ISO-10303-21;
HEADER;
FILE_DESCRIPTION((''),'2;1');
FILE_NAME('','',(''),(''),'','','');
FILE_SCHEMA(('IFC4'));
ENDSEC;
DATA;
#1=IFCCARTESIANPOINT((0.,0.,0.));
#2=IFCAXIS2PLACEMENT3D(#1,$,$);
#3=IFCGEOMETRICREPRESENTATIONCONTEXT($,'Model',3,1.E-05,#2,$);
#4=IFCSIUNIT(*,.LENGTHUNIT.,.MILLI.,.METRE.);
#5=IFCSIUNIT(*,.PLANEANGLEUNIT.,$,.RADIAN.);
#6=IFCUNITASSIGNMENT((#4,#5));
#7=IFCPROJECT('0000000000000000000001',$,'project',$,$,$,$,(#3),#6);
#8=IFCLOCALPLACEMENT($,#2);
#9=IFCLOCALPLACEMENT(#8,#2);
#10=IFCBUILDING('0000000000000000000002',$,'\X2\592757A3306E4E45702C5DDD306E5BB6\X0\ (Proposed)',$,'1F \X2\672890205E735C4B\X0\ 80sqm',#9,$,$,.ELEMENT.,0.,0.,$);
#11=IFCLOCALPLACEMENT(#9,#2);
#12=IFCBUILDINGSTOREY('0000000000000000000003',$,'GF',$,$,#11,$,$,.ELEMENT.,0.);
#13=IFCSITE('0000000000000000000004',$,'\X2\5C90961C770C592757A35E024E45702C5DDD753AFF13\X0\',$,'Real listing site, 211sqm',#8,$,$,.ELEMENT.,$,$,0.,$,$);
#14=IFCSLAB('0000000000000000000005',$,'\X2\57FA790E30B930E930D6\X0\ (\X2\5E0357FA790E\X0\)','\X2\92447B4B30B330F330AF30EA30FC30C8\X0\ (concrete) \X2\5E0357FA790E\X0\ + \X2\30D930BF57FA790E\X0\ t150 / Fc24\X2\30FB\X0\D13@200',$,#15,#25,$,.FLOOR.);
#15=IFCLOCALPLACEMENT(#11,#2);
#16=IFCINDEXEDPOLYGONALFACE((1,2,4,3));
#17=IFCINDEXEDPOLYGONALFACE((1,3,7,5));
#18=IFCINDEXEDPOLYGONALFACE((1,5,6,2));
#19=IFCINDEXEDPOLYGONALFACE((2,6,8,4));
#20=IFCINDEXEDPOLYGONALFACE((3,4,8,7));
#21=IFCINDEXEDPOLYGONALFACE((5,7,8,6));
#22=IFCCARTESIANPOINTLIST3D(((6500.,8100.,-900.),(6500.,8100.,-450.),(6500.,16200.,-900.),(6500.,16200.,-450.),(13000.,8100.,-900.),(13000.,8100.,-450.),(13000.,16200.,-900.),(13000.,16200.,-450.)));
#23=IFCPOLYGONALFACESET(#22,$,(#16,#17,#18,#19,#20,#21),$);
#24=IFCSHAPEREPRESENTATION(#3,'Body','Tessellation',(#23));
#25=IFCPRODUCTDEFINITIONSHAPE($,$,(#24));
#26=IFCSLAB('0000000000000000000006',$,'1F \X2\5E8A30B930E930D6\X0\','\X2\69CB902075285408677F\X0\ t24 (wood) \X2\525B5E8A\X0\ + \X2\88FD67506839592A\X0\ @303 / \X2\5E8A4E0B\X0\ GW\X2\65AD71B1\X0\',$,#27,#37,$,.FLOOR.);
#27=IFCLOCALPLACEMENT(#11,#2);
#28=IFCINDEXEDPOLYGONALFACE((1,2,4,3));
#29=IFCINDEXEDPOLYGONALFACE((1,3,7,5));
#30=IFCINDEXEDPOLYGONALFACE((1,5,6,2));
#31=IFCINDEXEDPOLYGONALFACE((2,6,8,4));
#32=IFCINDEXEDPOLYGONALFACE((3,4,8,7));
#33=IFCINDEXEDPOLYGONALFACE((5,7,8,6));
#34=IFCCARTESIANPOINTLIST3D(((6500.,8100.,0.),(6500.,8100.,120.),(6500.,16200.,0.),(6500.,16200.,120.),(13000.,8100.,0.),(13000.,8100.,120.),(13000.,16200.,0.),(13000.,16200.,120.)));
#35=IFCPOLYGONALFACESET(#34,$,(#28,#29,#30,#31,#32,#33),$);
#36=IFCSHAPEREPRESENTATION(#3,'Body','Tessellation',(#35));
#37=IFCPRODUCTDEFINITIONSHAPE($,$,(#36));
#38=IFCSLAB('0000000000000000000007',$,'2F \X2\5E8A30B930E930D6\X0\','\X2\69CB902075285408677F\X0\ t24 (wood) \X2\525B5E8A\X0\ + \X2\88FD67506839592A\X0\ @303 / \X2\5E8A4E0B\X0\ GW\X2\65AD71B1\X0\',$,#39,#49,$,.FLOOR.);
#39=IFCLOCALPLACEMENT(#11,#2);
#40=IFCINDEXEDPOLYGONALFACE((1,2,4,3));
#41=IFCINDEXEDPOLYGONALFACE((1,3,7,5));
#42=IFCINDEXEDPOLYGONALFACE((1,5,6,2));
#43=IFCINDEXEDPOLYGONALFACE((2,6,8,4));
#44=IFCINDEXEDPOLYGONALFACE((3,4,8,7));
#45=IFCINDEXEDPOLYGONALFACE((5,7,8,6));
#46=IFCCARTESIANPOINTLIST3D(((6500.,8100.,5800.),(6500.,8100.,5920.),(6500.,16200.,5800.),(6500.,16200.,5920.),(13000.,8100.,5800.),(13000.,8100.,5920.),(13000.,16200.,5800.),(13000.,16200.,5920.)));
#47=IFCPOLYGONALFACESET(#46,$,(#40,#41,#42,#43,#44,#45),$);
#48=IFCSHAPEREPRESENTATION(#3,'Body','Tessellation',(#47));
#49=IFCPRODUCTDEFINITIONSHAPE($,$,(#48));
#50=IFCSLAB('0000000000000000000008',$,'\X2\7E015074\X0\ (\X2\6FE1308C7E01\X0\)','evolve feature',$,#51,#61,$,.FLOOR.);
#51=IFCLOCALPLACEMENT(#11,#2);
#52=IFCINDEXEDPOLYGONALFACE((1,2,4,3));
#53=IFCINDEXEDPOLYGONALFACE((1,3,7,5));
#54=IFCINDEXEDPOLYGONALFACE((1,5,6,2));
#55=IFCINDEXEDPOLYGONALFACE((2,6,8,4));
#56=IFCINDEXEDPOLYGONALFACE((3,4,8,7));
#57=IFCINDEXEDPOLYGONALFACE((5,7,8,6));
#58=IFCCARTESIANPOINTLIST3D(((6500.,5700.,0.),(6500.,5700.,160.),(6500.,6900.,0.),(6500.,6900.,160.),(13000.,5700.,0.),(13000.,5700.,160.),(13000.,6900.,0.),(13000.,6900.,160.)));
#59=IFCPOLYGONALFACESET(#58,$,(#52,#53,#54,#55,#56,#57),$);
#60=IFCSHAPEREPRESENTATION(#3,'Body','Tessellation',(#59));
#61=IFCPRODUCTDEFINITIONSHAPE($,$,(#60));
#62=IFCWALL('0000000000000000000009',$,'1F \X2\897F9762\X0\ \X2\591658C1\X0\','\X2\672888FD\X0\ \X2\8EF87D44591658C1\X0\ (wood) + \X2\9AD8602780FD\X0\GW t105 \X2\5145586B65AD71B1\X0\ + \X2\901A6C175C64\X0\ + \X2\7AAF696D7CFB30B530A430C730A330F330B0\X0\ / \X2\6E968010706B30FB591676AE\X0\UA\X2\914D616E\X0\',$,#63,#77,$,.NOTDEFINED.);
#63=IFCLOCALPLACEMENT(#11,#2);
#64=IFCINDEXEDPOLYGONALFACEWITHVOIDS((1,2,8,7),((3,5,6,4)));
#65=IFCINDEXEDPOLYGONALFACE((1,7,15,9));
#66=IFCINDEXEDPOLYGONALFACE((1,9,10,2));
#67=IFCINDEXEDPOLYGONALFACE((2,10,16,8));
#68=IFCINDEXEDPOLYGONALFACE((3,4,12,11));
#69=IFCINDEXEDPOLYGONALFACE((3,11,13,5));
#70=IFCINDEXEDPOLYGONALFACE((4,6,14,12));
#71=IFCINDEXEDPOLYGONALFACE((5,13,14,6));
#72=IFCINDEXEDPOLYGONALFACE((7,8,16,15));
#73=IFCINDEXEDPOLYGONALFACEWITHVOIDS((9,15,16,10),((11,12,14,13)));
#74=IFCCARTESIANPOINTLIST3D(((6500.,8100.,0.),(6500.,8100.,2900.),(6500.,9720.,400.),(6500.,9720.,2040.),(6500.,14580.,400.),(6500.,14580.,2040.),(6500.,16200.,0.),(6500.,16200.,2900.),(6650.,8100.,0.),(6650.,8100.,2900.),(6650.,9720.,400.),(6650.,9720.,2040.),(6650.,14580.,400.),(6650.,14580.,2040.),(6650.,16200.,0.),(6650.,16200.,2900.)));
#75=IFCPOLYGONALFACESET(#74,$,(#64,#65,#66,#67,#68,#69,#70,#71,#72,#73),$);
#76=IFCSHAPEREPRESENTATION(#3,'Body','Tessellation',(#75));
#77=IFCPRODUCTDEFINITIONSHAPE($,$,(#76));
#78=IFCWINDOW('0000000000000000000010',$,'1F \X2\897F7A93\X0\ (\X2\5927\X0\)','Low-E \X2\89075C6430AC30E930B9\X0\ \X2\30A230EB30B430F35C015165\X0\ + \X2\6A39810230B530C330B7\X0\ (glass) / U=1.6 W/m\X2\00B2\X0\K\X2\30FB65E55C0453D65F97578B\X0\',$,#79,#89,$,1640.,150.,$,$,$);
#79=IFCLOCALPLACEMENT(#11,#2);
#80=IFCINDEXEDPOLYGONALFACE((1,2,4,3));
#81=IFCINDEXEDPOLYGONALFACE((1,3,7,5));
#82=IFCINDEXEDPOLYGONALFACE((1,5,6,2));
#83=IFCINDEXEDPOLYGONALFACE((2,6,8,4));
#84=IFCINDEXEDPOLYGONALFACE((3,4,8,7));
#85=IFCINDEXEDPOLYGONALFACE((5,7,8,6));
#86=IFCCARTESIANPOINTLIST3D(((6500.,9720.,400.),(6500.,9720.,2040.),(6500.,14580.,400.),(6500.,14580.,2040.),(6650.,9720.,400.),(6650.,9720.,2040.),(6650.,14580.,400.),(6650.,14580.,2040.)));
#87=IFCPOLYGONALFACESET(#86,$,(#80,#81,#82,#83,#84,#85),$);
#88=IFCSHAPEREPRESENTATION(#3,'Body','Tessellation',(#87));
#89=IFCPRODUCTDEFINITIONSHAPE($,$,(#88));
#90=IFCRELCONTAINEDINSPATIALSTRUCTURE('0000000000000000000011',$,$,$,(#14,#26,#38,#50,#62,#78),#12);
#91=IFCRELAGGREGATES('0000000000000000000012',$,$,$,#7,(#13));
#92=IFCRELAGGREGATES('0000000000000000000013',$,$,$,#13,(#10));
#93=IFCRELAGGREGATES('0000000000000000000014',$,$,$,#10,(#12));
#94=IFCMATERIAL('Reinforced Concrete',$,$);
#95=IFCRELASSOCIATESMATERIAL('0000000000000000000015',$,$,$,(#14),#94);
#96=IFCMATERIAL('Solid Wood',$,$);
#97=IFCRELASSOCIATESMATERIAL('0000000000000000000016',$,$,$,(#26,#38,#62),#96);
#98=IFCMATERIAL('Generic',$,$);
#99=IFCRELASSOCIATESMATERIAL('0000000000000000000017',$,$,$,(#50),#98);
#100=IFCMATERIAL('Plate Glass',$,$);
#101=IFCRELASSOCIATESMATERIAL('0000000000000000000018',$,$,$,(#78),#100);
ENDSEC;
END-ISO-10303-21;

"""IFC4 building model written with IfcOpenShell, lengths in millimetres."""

from ifc_helpers import new_model, si_unit, frame, frame_2d, origin, place, context, project, spatial, rectangle, extrude, material, element, fill, save


model = new_model("IFC4")

# Units and contexts
model_context = context("Model", 3, precision=1e-05, world=origin())
ifc_project = project(units=[si_unit("LENGTHUNIT", "METRE", prefix="MILLI"), si_unit("PLANEANGLEUNIT", "RADIAN")], contexts=[model_context])

# Site, building, storey
site_placement = place(None, origin())
site = spatial("IfcSite", under=ifc_project, at=site_placement, Name="岐阜県大垣市久瀬川町３", ObjectType="Real listing site, 211sqm", CompositionType="ELEMENT", RefElevation=0.0)
building_placement = place(site_placement, origin())
building = spatial("IfcBuilding", under=site, at=building_placement, Name="大垣の久瀬川の家 (Proposed)", ObjectType="1F 木造平屋 80sqm", CompositionType="ELEMENT", ElevationOfRefHeight=0.0, ElevationOfTerrain=0.0)
storey_placement = place(building_placement, origin())
storey = spatial("IfcBuildingStorey", under=building, at=storey_placement, Name="GF", CompositionType="ELEMENT", Elevation=0.0)

# Slabs
ifc_material_1 = material(Name="Reinforced Concrete")
slab_1_placement = place(storey_placement, frame((3250.0, 4050.0, -450.0)))
element("IfcSlab", 1, at=slab_1_placement, inside=storey, material=ifc_material_1, Name="基礎スラブ (布基礎)", Description="鉄筋コンクリート (concrete) 布基礎 + ベタ基礎 t150 / Fc24・D13@200", PredefinedType="FLOOR", context=model_context, shape_type="SweptSolid", body=[
    extrude(rectangle(XDim=6500.0, YDim=8100.0, at=frame_2d((3250.0, 4050.0))), frame((3250.0, 4050.0, -450.0)), (0.0, 0.0, 1.0), 450.0),
])
ifc_material_2 = material(Name="Solid Wood")
slab_2_placement = place(storey_placement, frame((3250.0, 4050.0, 0.0)))
element("IfcSlab", 2, at=slab_2_placement, inside=storey, material=ifc_material_2, Name="1F 床スラブ", Description="構造用合板 t24 (wood) 剛床 + 製材根太 @303 / 床下 GW断熱", PredefinedType="FLOOR", context=model_context, shape_type="SweptSolid", body=[
    extrude(rectangle(XDim=6500.0, YDim=8100.0, at=frame_2d((3250.0, 4050.0))), frame((3250.0, 4050.0, 0.0)), (0.0, 0.0, 1.0), 120.0),
])
slab_3_placement = place(storey_placement, frame((3250.0, 4050.0, 2900.0)))
element("IfcSlab", 3, at=slab_3_placement, inside=storey, material=ifc_material_2, Name="2F 床スラブ", Description="構造用合板 t24 (wood) 剛床 + 製材根太 @303 / 床下 GW断熱", PredefinedType="FLOOR", context=model_context, shape_type="SweptSolid", body=[
    extrude(rectangle(XDim=6500.0, YDim=8100.0, at=frame_2d((3250.0, 4050.0))), frame((3250.0, 4050.0, 2900.0)), (0.0, 0.0, 1.0), 120.0),
])
ifc_material_3 = material(Name="Generic")
slab_4_placement = place(storey_placement, frame((3250.0, 2850.0, 0.0)))
element("IfcSlab", 4, at=slab_4_placement, inside=storey, material=ifc_material_3, Name="縁側 (濡れ縁)", Description="evolve feature", PredefinedType="FLOOR", context=model_context, shape_type="SweptSolid", body=[
    extrude(rectangle(XDim=6500.0, YDim=1200.0, at=frame_2d((3250.0, 600.0))), frame((3250.0, 2850.0, 0.0)), (0.0, 0.0, 1.0), 160.0),
])

# Shared definitions
ifc_material_4 = material(Name="Plate Glass")

# Wall, opening, window
wall_1_placement = place(storey_placement, frame((3250.0, 4050.0, 0.0)))
wall_1 = element("IfcWall", 5, at=wall_1_placement, inside=storey, material=ifc_material_2, Name="1F 西面 外壁", Description="木製 軸組外壁 (wood) + 高性能GW t105 充填断熱 + 通気層 + 窯業系サイディング / 準耐火・外皮UA配慮", PredefinedType="NOTDEFINED", context=model_context, shape_type="SweptSolid", body=[
    extrude(rectangle(XDim=150.0, YDim=8100.0, at=frame_2d((75.0, 4050.0))), frame((3250.0, 4050.0, 0.0)), (0.0, 0.0, 1.0), 2900.0),
])
opening_1_placement = place(storey_placement, frame((3250.0, 4860.0, 200.0)))
opening_1 = element("IfcOpeningElement", 6, at=opening_1_placement, cuts=wall_1, PredefinedType="NOTDEFINED", context=model_context, shape_type="SweptSolid", body=[
    extrude(rectangle(XDim=150.0, YDim=4860.0, at=frame_2d((75.0, 2430.0))), frame((3250.0, 4860.0, 200.0)), (0.0, 0.0, 1.0), 1640.0),
])
window_1_placement = place(storey_placement, frame((3250.0, 4860.0, 200.0)))
window_1 = element("IfcWindow", 7, at=window_1_placement, inside=storey, material=ifc_material_4, Name="1F 西窓 (大)", Description="Low-E 複層ガラス アルゴン封入 + 樹脂サッシ (glass) / U=1.6 W/m²K・日射取得型", OverallHeight=1640.0, OverallWidth=150.0, context=model_context, shape_type="SweptSolid", body=[
    extrude(rectangle(XDim=150.0, YDim=4860.0, at=frame_2d((75.0, 2430.0))), frame((3250.0, 4860.0, 200.0)), (0.0, 0.0, 1.0), 1640.0),
])
fill(opening_1, window_1)

save(model, "model.ifc")
